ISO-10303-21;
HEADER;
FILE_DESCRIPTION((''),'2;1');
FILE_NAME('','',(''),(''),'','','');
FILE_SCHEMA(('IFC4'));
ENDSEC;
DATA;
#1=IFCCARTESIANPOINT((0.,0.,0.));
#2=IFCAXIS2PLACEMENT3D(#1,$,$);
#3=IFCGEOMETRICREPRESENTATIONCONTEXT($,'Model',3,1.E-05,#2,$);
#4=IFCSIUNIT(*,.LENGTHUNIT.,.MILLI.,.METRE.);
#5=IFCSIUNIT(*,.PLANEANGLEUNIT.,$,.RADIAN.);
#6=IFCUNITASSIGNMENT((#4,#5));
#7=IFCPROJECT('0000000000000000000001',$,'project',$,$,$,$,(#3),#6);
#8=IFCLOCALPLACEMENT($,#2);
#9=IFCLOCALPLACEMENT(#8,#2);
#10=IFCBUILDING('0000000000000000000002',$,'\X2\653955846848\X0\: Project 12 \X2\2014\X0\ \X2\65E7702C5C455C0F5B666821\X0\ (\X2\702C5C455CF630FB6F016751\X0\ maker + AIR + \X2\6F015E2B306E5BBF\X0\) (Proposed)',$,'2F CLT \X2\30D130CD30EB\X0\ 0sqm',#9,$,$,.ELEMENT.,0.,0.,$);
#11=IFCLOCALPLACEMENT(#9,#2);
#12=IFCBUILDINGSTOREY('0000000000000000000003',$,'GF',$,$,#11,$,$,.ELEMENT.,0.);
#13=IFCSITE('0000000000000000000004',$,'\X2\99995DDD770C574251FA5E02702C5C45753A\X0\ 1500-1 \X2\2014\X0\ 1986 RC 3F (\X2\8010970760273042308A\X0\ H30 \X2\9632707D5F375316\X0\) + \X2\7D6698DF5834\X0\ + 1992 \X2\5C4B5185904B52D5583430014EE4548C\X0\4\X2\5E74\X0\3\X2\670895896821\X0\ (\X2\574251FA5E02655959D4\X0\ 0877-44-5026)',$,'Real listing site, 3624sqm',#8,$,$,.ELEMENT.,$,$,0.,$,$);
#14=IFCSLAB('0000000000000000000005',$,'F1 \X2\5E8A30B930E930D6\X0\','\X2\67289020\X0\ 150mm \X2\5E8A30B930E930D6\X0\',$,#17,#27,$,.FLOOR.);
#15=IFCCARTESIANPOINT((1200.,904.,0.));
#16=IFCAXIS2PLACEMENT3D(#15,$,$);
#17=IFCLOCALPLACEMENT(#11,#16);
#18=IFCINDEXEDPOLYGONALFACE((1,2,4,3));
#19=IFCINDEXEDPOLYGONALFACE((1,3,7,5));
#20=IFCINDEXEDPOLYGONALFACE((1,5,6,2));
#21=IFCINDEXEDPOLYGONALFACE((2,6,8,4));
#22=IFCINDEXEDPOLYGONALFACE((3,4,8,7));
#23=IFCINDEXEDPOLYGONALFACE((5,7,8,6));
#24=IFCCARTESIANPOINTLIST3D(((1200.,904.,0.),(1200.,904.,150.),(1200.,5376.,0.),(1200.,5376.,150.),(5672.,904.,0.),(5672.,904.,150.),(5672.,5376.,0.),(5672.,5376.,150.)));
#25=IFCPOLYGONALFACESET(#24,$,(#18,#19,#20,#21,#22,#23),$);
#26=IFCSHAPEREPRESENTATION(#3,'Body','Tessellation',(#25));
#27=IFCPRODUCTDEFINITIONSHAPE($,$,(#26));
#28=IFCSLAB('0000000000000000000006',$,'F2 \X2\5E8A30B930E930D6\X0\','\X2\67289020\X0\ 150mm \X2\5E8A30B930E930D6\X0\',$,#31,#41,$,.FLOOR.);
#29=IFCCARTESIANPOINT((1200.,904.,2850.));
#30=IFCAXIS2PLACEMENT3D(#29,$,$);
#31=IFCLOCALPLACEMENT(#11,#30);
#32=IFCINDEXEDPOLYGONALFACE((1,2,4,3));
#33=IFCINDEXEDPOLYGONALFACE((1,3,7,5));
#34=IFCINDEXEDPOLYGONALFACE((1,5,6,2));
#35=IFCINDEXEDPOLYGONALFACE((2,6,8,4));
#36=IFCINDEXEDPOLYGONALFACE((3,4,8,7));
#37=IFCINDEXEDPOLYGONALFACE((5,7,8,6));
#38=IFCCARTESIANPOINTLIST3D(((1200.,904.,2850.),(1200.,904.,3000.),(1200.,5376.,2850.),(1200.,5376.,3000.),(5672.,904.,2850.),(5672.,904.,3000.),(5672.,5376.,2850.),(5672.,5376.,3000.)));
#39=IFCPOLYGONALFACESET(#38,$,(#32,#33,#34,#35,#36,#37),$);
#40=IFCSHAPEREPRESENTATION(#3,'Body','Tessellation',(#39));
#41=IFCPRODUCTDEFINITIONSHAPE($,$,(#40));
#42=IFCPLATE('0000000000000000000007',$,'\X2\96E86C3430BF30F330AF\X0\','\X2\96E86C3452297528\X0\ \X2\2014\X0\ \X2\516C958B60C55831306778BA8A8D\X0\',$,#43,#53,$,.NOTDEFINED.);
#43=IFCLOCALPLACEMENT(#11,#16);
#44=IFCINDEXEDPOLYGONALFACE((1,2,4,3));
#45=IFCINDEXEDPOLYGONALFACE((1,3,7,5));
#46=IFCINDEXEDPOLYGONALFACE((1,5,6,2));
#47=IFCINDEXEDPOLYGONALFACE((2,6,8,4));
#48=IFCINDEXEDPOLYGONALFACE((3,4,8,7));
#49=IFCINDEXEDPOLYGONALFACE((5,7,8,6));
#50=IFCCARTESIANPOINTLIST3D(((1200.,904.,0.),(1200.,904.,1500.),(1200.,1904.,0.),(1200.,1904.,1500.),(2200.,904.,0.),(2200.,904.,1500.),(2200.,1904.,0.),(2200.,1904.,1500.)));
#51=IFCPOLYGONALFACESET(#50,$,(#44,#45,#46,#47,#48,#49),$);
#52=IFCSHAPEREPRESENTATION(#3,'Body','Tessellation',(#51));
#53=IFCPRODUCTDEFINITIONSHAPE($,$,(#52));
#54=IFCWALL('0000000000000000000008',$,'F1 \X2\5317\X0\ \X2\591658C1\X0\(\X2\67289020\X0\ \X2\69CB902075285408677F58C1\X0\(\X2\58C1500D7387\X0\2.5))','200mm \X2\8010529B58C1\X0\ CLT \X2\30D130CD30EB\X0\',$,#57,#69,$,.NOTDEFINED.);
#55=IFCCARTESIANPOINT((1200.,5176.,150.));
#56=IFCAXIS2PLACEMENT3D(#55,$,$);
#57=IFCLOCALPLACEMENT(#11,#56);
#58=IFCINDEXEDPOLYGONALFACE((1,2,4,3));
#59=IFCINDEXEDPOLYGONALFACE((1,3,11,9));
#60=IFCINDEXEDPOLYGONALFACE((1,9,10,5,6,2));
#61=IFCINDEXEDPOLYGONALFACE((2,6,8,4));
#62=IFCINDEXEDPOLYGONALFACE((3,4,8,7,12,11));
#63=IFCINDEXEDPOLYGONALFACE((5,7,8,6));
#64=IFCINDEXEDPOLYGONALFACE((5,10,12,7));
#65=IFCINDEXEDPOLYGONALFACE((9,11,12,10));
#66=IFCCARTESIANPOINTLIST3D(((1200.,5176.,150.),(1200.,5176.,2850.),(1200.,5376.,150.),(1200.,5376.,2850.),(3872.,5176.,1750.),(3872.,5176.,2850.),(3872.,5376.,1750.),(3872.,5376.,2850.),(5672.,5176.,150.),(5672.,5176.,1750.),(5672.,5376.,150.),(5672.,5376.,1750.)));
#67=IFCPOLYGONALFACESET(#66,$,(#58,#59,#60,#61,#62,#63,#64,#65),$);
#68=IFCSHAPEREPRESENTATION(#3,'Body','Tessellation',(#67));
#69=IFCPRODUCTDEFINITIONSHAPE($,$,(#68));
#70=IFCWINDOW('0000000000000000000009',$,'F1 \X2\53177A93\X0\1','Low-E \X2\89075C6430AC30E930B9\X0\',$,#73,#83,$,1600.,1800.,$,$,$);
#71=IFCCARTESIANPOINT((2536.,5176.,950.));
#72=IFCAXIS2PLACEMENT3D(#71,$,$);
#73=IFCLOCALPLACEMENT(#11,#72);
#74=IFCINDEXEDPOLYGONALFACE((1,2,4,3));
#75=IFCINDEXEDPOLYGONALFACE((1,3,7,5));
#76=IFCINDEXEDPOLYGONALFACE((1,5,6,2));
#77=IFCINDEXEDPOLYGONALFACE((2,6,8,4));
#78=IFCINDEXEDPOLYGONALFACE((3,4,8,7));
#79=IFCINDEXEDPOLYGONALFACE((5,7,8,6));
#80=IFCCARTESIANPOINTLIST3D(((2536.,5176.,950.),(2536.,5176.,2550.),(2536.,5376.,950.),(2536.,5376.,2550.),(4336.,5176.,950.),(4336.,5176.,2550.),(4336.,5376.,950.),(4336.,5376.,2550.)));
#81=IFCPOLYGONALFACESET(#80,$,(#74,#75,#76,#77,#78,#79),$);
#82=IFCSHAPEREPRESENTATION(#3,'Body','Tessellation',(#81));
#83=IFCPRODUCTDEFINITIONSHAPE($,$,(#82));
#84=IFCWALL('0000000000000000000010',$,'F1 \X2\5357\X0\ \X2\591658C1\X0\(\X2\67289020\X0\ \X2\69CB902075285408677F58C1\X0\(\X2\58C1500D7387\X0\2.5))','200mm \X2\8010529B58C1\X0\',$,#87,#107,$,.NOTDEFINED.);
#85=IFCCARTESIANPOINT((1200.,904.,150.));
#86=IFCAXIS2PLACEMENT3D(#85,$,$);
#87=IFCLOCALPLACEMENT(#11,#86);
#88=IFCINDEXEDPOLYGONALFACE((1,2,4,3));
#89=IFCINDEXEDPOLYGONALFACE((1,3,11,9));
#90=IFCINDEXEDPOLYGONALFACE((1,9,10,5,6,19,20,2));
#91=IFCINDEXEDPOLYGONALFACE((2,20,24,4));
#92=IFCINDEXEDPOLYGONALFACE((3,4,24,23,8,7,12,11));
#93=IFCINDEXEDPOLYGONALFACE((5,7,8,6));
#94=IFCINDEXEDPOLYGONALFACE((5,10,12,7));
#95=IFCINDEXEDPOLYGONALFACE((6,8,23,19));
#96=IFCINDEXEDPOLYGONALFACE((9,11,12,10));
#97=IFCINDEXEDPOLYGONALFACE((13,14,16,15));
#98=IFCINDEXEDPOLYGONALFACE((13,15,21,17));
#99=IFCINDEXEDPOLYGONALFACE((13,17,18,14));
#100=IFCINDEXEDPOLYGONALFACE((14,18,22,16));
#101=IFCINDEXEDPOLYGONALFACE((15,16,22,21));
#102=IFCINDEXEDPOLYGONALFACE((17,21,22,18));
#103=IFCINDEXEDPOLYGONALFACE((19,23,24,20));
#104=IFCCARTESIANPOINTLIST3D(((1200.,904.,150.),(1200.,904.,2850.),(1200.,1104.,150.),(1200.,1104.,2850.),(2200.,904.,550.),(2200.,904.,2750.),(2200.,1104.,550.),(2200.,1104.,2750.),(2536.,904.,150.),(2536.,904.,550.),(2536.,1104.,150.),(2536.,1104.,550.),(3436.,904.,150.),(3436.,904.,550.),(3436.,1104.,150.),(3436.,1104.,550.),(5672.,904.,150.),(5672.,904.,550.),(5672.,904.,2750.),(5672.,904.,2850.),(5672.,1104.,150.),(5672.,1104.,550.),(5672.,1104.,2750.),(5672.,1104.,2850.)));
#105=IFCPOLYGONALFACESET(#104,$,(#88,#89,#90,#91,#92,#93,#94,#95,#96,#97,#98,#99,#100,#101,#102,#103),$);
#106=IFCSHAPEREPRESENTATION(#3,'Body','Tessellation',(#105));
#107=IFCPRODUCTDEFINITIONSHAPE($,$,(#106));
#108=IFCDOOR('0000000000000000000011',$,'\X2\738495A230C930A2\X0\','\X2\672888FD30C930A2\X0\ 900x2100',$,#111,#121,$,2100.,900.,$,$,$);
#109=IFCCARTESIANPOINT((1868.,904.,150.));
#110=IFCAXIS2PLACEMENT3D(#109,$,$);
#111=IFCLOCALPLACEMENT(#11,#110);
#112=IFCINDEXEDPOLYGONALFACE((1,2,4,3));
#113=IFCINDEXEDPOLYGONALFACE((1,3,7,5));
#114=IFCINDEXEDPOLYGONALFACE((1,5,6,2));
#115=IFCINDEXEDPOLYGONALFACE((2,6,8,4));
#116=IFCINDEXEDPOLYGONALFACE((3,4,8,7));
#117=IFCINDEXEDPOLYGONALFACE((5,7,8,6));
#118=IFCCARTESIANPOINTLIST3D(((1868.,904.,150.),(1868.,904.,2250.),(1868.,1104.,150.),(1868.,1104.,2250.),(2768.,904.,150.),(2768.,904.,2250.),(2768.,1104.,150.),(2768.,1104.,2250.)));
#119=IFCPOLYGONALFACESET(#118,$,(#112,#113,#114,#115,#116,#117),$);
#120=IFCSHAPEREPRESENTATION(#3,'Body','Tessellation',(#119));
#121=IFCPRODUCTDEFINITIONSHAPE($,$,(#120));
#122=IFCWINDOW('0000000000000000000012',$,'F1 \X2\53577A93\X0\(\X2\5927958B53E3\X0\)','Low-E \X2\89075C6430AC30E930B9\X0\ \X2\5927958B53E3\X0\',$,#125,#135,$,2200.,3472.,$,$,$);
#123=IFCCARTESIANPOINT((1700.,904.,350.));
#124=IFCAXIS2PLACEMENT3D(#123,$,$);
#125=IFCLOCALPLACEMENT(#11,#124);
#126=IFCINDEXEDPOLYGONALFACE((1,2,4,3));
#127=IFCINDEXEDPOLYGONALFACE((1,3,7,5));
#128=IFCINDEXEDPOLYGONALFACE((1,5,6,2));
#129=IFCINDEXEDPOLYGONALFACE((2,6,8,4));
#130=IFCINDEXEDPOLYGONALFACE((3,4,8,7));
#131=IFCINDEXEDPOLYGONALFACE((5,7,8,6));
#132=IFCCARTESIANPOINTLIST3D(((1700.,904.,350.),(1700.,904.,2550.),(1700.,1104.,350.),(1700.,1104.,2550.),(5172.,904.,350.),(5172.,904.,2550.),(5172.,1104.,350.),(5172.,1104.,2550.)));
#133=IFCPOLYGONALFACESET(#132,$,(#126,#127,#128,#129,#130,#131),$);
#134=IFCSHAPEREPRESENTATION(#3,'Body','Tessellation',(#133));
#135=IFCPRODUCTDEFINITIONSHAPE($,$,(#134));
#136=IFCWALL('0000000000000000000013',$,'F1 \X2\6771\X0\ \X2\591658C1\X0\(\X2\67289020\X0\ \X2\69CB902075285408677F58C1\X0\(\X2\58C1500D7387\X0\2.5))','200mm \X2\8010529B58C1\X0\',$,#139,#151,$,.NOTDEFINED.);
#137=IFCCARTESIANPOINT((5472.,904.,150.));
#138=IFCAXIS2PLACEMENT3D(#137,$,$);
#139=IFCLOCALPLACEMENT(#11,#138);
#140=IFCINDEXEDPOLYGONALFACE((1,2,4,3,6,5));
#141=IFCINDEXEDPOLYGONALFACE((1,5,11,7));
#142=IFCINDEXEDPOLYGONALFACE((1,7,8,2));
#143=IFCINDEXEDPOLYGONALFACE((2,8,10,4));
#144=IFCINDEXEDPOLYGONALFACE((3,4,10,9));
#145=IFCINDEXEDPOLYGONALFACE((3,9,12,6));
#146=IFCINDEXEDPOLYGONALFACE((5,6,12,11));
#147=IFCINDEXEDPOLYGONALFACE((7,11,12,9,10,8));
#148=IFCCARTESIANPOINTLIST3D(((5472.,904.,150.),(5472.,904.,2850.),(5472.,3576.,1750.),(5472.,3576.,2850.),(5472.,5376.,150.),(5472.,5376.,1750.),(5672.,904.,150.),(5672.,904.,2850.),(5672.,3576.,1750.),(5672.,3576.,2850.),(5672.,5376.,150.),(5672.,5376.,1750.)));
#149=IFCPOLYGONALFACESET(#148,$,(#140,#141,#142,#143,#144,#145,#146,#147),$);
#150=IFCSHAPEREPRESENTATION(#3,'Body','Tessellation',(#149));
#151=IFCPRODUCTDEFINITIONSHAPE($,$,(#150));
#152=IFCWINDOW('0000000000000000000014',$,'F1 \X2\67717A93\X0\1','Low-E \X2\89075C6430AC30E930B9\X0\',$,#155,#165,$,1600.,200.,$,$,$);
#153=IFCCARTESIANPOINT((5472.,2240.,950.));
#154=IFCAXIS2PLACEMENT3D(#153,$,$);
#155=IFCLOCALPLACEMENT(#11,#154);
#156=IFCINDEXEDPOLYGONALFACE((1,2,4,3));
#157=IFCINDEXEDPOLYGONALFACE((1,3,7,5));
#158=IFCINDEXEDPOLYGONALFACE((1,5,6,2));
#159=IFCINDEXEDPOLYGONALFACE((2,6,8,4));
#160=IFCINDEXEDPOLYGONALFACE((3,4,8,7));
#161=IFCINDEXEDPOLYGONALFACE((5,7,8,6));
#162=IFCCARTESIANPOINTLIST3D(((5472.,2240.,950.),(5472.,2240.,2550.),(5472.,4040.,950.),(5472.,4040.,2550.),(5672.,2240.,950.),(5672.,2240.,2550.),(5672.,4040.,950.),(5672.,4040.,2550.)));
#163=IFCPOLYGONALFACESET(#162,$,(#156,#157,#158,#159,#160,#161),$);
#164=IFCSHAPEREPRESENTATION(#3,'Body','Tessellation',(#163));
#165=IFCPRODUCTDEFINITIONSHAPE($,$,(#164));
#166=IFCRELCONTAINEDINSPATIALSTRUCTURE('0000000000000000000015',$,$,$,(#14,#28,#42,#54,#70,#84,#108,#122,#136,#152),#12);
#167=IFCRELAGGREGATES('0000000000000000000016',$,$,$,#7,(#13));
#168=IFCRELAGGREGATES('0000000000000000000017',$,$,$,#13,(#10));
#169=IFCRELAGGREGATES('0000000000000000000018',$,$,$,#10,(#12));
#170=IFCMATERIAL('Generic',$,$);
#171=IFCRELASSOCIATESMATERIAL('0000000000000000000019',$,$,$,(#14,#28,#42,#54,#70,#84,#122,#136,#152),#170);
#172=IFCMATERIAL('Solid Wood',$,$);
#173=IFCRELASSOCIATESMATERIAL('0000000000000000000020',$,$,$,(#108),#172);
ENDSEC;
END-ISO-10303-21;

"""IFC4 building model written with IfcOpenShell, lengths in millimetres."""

from ifc_helpers import new_model, si_unit, frame, frame_2d, origin, place, context, project, spatial, rectangle, extrude, material, element, fill, save


model = new_model("IFC4")

# Units and contexts
model_context = context("Model", 3, precision=1e-05, world=origin())
ifc_project = project(units=[si_unit("LENGTHUNIT", "METRE", prefix="MILLI"), si_unit("PLANEANGLEUNIT", "RADIAN")], contexts=[model_context])

# Site, building, storey
site_placement = place(None, origin())
site = spatial("IfcSite", under=ifc_project, at=site_placement, Name="香川県坂出市瀬居町 1500-1 — 1986 RC 3F (耐震性あり H30 防災強化) + 給食場 + 1992 屋内運動場、令和4年3月閉校 (坂出市教委 0877-44-5026)", ObjectType="Real listing site, 3624sqm", CompositionType="ELEMENT", RefElevation=0.0)
building_placement = place(site_placement, origin())
building = spatial("IfcBuilding", under=site, at=building_placement, Name="改善案: Project 12 — 旧瀬居小学校 (瀬居島・漁村 maker + AIR + 漁師の宿) (Proposed)", ObjectType="2F CLT パネル 0sqm", CompositionType="ELEMENT", ElevationOfRefHeight=0.0, ElevationOfTerrain=0.0)
storey_placement = place(building_placement, origin())
storey = spatial("IfcBuildingStorey", under=building, at=storey_placement, Name="GF", CompositionType="ELEMENT", Elevation=0.0)

# Slabs
ifc_material_1 = material(Name="Generic")
slab_1_placement = place(storey_placement, frame((1200.0, 904.0, 0.0)))
element("IfcSlab", 1, at=slab_1_placement, inside=storey, material=ifc_material_1, Name="F1 床スラブ", Description="木造 150mm 床スラブ", PredefinedType="FLOOR", context=model_context, shape_type="SweptSolid", body=[
    extrude(rectangle(XDim=4472.0, YDim=4472.0, at=frame_2d((2236.0, 2236.0))), frame((1200.0, 904.0, 0.0)), (0.0, 0.0, 1.0), 150.0),
])
slab_2_placement = place(storey_placement, frame((1200.0, 904.0, 2850.0)))
element("IfcSlab", 2, at=slab_2_placement, inside=storey, material=ifc_material_1, Name="F2 床スラブ", Description="木造 150mm 床スラブ", PredefinedType="FLOOR", context=model_context, shape_type="SweptSolid", body=[
    extrude(rectangle(XDim=4472.0, YDim=4472.0, at=frame_2d((2236.0, 2236.0))), frame((1200.0, 904.0, 2850.0)), (0.0, 0.0, 1.0), 150.0),
])

# Plate
plate_placement = place(storey_placement, frame((1200.0, 904.0, 0.0)))
element("IfcPlate", 3, at=plate_placement, inside=storey, material=ifc_material_1, Name="雨水タンク", Description="雨水利用 — 公開情報で確認", PredefinedType="NOTDEFINED", context=model_context, shape_type="SweptSolid", body=[
    extrude(rectangle(XDim=1000.0, YDim=1000.0, at=frame_2d((500.0, 500.0))), frame((1200.0, 904.0, 0.0)), (0.0, 0.0, 1.0), 1500.0),
])

# Wall, opening, window
wall_1_placement = place(storey_placement, frame((1200.0, 5176.0, 150.0)))
wall_1 = element("IfcWall", 4, at=wall_1_placement, inside=storey, material=ifc_material_1, Name="F1 北 外壁(木造 構造用合板壁(壁倍率2.5))", Description="200mm 耐力壁 CLT パネル", PredefinedType="NOTDEFINED", context=model_context, shape_type="SweptSolid", body=[
    extrude(rectangle(XDim=4472.0, YDim=200.0, at=frame_2d((2236.0, 100.0))), frame((1200.0, 5176.0, 150.0)), (0.0, 0.0, 1.0), 2700.0),
])
opening_1_placement = place(storey_placement, frame((2536.0, 5176.0, 950.0)))
opening_1 = element("IfcOpeningElement", 5, at=opening_1_placement, cuts=wall_1, PredefinedType="NOTDEFINED", context=model_context, shape_type="SweptSolid", body=[
    extrude(rectangle(XDim=1800.0, YDim=200.0, at=frame_2d((900.0, 100.0))), frame((2536.0, 5176.0, 950.0)), (0.0, 0.0, 1.0), 1600.0),
])
window_1_placement = place(storey_placement, frame((2536.0, 5176.0, 950.0)))
window_1 = element("IfcWindow", 6, at=window_1_placement, inside=storey, material=ifc_material_1, Name="F1 北窓1", Description="Low-E 複層ガラス", OverallHeight=1600.0, OverallWidth=1800.0, context=model_context, shape_type="SweptSolid", body=[
    extrude(rectangle(XDim=1800.0, YDim=200.0, at=frame_2d((900.0, 100.0))), frame((2536.0, 5176.0, 950.0)), (0.0, 0.0, 1.0), 1600.0),
])
fill(opening_1, window_1)

# Wall, openings, door, window
wall_2_placement = place(storey_placement, frame((1200.0, 904.0, 150.0)))
wall_2 = element("IfcWall", 7, at=wall_2_placement, inside=storey, material=ifc_material_1, Name="F1 南 外壁(木造 構造用合板壁(壁倍率2.5))", Description="200mm 耐力壁", PredefinedType="NOTDEFINED", context=model_context, shape_type="SweptSolid", body=[
    extrude(rectangle(XDim=4472.0, YDim=200.0, at=frame_2d((2236.0, 100.0))), frame((1200.0, 904.0, 150.0)), (0.0, 0.0, 1.0), 2700.0),
])
opening_2_placement = place(storey_placement, frame((1868.0, 904.0, 150.0)))
opening_2 = element("IfcOpeningElement", 8, at=opening_2_placement, cuts=wall_2, PredefinedType="NOTDEFINED", context=model_context, shape_type="SweptSolid", body=[
    extrude(rectangle(XDim=900.0, YDim=200.0, at=frame_2d((450.0, 100.0))), frame((1868.0, 904.0, 150.0)), (0.0, 0.0, 1.0), 2100.0),
])
opening_3_placement = place(storey_placement, frame((1700.0, 904.0, 350.0)))
opening_3 = element("IfcOpeningElement", 9, at=opening_3_placement, cuts=wall_2, PredefinedType="NOTDEFINED", context=model_context, shape_type="SweptSolid", body=[
    extrude(rectangle(XDim=3472.0, YDim=200.0, at=frame_2d((1736.0, 100.0))), frame((1700.0, 904.0, 350.0)), (0.0, 0.0, 1.0), 2200.0),
])
ifc_material_2 = material(Name="Solid Wood")
door_placement = place(storey_placement, frame((1868.0, 904.0, 150.0)))
door = element("IfcDoor", 10, at=door_placement, inside=storey, material=ifc_material_2, Name="玄関ドア", Description="木製ドア 900x2100", OverallHeight=2100.0, OverallWidth=900.0, context=model_context, shape_type="SweptSolid", body=[
    extrude(rectangle(XDim=900.0, YDim=200.0, at=frame_2d((450.0, 100.0))), frame((1868.0, 904.0, 150.0)), (0.0, 0.0, 1.0), 2100.0),
])
fill(opening_2, door)
window_2_placement = place(storey_placement, frame((1700.0, 904.0, 350.0)))
window_2 = element("IfcWindow", 11, at=window_2_placement, inside=storey, material=ifc_material_1, Name="F1 南窓(大開口)", Description="Low-E 複層ガラス 大開口", OverallHeight=2200.0, OverallWidth=3472.0, context=model_context, shape_type="SweptSolid", body=[
    extrude(rectangle(XDim=3472.0, YDim=200.0, at=frame_2d((1736.0, 100.0))), frame((1700.0, 904.0, 350.0)), (0.0, 0.0, 1.0), 2200.0),
])
fill(opening_3, window_2)

# Wall, opening, window
wall_3_placement = place(storey_placement, frame((5472.0, 904.0, 150.0)))
wall_3 = element("IfcWall", 12, at=wall_3_placement, inside=storey, material=ifc_material_1, Name="F1 東 外壁(木造 構造用合板壁(壁倍率2.5))", Description="200mm 耐力壁", PredefinedType="NOTDEFINED", context=model_context, shape_type="SweptSolid", body=[
    extrude(rectangle(XDim=200.0, YDim=4472.0, at=frame_2d((100.0, 2236.0))), frame((5472.0, 904.0, 150.0)), (0.0, 0.0, 1.0), 2700.0),
])
opening_4_placement = place(storey_placement, frame((5472.0, 2240.0, 950.0)))
opening_4 = element("IfcOpeningElement", 13, at=opening_4_placement, cuts=wall_3, PredefinedType="NOTDEFINED", context=model_context, shape_type="SweptSolid", body=[
    extrude(rectangle(XDim=200.0, YDim=1800.0, at=frame_2d((100.0, 900.0))), frame((5472.0, 2240.0, 950.0)), (0.0, 0.0, 1.0), 1600.0),
])
window_3_placement = place(storey_placement, frame((5472.0, 2240.0, 950.0)))
window_3 = element("IfcWindow", 14, at=window_3_placement, inside=storey, material=ifc_material_1, Name="F1 東窓1", Description="Low-E 複層ガラス", OverallHeight=1600.0, OverallWidth=200.0, context=model_context, shape_type="SweptSolid", body=[
    extrude(rectangle(XDim=200.0, YDim=1800.0, at=frame_2d((100.0, 900.0))), frame((5472.0, 2240.0, 950.0)), (0.0, 0.0, 1.0), 1600.0),
])
fill(opening_4, window_3)

save(model, "model.ifc")
